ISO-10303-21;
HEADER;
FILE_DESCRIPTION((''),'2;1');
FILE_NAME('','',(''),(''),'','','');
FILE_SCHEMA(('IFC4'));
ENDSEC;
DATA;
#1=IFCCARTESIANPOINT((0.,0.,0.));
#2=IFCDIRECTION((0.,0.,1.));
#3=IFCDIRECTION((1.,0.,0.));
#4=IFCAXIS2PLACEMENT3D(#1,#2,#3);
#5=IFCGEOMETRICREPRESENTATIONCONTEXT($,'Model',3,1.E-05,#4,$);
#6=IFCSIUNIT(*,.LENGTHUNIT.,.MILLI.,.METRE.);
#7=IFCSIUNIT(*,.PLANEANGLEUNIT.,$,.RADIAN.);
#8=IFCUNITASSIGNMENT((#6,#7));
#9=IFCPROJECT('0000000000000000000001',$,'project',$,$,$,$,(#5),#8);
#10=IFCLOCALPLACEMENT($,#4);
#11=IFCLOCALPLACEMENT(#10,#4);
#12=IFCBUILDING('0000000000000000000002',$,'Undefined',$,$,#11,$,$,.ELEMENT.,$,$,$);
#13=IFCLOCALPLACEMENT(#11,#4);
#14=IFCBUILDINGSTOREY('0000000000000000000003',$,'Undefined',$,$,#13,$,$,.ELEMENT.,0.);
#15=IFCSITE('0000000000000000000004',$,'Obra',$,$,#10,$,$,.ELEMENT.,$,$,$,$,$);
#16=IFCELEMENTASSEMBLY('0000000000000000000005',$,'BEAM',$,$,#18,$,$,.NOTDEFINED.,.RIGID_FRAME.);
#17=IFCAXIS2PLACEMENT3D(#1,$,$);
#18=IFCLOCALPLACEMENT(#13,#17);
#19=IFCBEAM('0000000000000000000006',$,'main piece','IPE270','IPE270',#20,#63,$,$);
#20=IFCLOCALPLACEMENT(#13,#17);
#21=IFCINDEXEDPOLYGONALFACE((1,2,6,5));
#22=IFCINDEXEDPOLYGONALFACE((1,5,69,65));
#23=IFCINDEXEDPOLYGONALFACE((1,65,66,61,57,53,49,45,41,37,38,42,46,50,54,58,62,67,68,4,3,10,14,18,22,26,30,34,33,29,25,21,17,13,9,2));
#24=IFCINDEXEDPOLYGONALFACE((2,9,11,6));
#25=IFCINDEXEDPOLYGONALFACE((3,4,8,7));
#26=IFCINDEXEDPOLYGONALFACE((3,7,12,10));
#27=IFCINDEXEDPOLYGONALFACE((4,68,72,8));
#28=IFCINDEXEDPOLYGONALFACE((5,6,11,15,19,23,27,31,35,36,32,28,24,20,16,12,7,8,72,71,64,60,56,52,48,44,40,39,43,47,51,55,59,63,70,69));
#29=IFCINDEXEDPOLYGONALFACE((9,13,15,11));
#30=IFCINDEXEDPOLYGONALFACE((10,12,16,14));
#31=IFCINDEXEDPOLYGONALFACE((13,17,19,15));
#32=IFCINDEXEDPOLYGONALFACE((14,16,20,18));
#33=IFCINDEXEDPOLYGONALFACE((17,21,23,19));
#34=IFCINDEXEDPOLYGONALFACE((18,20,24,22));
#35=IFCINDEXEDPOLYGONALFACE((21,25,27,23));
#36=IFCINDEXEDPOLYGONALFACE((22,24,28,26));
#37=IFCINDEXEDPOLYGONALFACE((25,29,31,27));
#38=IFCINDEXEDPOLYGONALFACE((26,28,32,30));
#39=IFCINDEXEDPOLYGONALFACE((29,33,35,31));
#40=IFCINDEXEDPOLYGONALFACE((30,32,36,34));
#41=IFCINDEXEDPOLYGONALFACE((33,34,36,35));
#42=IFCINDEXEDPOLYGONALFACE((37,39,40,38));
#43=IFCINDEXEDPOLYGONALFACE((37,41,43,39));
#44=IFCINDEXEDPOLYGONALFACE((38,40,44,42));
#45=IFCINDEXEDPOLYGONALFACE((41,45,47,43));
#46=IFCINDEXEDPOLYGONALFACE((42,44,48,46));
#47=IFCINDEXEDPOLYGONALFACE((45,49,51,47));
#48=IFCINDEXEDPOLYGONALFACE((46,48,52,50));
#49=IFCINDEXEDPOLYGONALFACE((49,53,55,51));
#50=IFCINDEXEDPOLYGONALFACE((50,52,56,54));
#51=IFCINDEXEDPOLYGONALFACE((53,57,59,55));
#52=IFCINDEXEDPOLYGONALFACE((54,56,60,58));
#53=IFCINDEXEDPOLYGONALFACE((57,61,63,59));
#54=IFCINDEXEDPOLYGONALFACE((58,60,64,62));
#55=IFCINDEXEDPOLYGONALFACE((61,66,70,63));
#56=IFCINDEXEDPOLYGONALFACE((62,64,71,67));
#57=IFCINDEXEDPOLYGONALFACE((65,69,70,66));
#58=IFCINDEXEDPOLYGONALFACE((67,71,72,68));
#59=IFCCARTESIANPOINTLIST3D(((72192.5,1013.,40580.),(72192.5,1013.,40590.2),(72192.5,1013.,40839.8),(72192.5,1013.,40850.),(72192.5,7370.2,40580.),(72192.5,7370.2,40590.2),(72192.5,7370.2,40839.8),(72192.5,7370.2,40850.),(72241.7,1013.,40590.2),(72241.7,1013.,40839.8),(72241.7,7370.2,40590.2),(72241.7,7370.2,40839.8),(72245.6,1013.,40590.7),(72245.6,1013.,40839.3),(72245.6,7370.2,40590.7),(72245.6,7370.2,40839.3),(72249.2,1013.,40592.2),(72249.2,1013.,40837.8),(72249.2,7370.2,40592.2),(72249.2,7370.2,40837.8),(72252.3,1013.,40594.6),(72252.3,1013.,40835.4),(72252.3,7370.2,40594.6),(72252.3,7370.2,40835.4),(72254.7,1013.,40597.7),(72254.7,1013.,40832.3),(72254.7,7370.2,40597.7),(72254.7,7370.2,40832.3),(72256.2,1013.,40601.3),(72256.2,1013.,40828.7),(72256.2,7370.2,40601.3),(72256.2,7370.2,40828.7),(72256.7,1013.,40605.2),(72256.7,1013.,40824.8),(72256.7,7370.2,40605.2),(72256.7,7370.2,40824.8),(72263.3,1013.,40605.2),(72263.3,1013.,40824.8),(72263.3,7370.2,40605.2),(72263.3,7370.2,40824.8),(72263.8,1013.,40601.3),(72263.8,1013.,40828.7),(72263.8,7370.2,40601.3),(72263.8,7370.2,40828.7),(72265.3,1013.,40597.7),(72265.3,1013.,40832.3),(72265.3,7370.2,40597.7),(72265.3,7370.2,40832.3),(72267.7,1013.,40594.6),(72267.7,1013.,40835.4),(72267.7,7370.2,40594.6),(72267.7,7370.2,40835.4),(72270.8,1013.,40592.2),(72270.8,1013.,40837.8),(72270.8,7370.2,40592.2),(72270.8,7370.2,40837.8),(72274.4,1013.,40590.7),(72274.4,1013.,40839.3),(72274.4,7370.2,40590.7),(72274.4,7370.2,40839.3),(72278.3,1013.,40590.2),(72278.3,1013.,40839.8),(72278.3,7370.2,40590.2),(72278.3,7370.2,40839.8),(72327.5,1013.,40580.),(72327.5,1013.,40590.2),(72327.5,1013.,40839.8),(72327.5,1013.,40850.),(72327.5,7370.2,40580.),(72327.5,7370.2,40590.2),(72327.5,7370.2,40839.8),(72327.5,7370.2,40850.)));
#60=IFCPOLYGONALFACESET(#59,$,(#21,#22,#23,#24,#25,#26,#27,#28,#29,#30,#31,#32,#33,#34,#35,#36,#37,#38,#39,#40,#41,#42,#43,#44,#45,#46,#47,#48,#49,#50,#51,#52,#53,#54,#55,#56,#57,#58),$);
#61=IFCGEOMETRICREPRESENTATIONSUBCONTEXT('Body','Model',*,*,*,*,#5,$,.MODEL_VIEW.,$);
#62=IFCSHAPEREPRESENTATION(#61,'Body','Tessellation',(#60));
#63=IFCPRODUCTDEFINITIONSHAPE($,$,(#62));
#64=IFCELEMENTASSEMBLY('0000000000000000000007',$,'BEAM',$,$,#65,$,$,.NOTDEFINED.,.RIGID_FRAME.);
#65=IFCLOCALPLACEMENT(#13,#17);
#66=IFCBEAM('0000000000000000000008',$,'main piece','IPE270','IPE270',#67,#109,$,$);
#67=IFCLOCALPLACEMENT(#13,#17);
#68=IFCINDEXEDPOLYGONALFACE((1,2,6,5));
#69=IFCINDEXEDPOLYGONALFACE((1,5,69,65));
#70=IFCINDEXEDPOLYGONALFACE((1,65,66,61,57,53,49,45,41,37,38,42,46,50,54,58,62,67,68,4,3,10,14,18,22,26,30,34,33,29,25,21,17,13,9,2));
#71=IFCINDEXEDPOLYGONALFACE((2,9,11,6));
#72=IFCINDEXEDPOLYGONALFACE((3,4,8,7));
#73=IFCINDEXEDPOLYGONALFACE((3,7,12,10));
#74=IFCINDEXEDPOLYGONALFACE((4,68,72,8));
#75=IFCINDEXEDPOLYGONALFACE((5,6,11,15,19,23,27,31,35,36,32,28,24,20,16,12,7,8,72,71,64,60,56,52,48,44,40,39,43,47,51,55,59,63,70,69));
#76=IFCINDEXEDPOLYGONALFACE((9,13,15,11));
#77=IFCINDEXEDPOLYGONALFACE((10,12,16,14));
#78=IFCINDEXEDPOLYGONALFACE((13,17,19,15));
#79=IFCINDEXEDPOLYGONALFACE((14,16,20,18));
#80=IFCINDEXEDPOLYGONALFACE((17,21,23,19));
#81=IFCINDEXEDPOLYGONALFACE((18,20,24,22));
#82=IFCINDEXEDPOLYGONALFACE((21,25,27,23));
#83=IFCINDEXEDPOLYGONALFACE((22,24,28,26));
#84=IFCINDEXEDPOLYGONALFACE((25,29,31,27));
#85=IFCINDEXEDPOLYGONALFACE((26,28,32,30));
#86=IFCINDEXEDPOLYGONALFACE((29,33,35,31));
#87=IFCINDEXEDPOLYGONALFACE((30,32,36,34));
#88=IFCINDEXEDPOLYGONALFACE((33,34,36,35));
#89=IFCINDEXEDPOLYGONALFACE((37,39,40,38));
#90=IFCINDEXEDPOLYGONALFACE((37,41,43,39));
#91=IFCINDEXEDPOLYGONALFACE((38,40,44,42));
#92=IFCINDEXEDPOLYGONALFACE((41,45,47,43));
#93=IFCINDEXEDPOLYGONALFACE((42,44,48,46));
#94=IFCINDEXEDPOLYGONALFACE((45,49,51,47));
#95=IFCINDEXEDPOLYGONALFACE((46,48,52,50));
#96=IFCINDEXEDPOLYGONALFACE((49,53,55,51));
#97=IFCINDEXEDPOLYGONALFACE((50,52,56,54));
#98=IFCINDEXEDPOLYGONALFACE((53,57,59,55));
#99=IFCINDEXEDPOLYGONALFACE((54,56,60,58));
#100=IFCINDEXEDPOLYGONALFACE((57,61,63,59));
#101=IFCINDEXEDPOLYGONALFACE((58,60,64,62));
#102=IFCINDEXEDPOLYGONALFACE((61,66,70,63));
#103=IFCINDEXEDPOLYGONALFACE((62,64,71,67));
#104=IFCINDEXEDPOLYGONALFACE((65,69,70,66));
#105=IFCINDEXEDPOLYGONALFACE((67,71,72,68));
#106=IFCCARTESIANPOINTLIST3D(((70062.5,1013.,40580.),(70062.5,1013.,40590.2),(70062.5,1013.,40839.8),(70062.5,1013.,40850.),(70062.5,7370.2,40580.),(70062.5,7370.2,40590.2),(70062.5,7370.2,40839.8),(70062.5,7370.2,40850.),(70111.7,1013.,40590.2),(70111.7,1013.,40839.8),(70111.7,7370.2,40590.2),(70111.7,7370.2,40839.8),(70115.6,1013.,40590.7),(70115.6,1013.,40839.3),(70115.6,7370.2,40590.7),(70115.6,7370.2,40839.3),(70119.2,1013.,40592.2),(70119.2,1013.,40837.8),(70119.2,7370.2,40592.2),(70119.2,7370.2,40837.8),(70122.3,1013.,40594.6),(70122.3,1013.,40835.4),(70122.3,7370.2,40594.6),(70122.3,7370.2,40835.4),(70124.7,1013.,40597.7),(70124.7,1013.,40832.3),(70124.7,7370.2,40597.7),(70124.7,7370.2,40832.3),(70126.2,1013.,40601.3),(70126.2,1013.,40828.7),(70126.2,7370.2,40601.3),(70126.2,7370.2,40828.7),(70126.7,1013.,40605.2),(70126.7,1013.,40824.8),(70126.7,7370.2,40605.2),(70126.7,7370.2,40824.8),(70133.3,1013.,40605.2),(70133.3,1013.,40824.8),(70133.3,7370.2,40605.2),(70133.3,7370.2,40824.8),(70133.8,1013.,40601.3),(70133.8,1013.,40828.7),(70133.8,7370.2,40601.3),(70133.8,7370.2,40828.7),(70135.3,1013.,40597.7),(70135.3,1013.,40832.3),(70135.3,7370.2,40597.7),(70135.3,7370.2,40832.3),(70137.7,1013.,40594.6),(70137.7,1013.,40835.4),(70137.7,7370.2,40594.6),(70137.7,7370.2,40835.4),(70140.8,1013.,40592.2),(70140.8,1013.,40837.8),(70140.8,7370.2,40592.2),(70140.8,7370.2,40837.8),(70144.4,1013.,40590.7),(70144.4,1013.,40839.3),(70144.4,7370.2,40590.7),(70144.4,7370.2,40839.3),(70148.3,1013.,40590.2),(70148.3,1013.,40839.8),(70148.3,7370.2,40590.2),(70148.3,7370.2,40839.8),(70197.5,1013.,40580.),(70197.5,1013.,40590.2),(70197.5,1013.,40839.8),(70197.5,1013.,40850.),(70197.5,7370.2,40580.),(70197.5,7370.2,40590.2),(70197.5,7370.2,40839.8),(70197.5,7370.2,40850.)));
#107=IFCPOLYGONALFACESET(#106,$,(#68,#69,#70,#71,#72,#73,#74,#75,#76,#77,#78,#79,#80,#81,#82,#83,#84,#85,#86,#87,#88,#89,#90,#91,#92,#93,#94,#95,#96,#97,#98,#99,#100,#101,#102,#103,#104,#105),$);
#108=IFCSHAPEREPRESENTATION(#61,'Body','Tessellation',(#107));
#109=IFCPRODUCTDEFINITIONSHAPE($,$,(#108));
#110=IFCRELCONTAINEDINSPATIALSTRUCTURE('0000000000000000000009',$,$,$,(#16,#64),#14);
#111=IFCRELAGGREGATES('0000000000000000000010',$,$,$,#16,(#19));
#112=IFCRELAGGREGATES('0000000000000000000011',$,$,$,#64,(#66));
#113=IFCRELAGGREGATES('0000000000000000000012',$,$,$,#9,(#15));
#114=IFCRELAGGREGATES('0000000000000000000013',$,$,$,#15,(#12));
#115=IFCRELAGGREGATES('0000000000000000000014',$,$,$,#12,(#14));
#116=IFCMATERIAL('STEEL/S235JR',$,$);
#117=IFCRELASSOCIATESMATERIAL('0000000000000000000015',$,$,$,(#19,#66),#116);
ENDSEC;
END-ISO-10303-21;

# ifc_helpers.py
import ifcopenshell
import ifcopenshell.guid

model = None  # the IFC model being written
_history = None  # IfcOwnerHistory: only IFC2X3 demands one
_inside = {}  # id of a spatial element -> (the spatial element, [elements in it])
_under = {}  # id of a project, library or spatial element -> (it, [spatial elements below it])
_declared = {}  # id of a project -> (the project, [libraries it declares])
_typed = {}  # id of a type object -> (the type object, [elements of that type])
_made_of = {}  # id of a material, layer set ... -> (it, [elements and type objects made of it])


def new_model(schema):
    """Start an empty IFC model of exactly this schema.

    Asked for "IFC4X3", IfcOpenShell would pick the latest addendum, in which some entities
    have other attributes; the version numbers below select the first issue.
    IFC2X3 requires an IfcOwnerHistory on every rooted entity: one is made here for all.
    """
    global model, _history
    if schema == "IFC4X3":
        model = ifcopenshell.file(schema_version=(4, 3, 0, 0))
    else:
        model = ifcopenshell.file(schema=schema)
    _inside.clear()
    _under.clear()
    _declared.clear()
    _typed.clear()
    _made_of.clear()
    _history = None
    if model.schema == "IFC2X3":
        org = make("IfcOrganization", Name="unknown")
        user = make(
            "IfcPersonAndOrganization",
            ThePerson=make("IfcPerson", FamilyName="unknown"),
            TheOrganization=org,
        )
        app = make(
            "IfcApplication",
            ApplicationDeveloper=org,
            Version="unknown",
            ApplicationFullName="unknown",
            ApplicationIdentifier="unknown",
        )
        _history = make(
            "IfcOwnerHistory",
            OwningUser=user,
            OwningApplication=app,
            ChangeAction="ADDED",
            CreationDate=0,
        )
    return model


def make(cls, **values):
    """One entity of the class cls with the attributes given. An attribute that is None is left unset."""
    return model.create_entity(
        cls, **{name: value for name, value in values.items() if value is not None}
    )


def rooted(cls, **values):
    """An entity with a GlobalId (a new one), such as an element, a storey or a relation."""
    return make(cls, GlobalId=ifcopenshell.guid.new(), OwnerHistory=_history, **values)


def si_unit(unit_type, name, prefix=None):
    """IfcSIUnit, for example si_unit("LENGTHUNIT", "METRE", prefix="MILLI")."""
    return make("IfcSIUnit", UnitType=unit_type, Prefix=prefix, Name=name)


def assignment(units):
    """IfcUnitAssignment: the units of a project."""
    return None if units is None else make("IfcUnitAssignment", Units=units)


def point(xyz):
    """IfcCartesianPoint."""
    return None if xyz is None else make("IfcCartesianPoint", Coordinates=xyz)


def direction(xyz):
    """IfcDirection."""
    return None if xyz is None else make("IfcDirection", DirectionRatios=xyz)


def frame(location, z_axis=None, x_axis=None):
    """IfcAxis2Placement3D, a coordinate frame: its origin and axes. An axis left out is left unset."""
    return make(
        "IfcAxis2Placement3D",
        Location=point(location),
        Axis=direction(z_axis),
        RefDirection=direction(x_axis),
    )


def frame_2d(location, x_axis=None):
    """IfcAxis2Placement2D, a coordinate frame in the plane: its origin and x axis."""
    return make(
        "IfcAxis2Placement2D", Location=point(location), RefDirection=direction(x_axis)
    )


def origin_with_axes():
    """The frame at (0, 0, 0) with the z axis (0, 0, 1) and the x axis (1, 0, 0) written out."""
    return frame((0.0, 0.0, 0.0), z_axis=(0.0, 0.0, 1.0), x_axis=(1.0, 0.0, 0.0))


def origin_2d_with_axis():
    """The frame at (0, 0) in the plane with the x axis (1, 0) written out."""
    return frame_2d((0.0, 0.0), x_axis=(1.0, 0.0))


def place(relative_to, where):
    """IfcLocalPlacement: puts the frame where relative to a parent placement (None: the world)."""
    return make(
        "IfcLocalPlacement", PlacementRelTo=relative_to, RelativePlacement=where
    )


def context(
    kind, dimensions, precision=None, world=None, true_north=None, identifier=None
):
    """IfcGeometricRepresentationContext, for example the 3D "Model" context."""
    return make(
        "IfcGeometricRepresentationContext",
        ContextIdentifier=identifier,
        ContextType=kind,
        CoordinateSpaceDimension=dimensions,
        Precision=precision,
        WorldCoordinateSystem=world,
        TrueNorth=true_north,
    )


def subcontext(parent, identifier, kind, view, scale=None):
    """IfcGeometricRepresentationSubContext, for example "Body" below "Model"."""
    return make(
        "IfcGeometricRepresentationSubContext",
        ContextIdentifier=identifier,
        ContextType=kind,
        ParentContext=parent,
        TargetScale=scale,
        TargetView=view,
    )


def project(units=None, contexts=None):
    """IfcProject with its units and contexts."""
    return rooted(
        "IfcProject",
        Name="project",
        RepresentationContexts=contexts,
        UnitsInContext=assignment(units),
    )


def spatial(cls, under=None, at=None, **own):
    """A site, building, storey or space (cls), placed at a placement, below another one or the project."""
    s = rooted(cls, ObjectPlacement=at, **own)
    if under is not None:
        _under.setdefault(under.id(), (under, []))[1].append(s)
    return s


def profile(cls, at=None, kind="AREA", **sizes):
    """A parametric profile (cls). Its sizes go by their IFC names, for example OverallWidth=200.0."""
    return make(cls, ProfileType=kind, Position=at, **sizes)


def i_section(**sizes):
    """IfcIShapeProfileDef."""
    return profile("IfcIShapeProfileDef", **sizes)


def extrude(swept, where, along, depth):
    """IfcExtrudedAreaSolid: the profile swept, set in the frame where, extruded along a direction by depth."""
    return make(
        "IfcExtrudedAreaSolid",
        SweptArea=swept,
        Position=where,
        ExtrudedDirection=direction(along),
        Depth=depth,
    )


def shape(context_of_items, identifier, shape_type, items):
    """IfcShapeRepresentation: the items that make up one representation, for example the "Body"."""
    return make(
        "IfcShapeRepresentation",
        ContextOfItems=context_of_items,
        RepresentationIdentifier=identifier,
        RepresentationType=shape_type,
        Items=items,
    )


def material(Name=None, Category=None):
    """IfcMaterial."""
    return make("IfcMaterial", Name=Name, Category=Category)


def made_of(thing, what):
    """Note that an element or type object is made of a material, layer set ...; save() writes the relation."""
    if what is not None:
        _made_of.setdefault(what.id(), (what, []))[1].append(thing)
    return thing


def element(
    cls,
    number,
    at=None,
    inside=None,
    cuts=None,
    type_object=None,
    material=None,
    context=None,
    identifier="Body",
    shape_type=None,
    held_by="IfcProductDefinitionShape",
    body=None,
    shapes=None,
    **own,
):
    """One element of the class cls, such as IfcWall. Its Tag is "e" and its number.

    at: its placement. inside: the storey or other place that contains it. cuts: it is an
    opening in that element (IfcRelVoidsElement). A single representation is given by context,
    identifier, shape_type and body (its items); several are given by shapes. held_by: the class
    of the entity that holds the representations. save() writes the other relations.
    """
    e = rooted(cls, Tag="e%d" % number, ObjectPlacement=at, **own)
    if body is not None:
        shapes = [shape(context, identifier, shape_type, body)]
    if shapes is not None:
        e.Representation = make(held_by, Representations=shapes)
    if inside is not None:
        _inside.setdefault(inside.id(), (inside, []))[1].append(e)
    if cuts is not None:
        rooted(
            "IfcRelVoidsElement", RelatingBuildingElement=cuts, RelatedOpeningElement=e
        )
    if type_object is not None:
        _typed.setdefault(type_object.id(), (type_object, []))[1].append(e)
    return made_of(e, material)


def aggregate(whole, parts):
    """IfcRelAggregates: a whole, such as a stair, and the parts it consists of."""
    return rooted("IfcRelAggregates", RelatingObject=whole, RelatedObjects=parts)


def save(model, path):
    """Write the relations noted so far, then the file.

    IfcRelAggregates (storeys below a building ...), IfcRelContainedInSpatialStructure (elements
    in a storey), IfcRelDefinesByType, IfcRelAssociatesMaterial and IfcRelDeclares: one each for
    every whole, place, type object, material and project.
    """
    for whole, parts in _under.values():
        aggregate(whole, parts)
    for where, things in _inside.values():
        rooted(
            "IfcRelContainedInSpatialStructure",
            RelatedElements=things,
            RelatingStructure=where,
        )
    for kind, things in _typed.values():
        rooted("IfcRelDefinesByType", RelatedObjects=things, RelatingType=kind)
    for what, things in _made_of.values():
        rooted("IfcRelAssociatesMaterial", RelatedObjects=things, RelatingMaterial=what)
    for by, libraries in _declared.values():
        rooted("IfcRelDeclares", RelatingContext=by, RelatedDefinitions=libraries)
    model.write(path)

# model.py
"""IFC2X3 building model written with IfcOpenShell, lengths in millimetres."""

from ifc_helpers import new_model, si_unit, frame, origin_with_axes, origin_2d_with_axis, place, context, subcontext, project, spatial, i_section, extrude, material, element, aggregate, save


model = new_model("IFC2X3")

# Units and contexts
model_context = context("Model", 3, precision=1e-05, world=origin_with_axes())
body_context = subcontext(model_context, "Body", "Model", "MODEL_VIEW")
ifc_project = project(units=[si_unit("LENGTHUNIT", "METRE", prefix="MILLI"), si_unit("PLANEANGLEUNIT", "RADIAN")], contexts=[model_context])

# Site, building, storey
site_placement = place(None, origin_with_axes())
site = spatial("IfcSite", under=ifc_project, at=site_placement, Name="Obra", CompositionType="ELEMENT")
building_placement = place(site_placement, origin_with_axes())
building = spatial("IfcBuilding", under=site, at=building_placement, Name="Undefined", CompositionType="ELEMENT")
storey_placement = place(building_placement, origin_with_axes())
storey = spatial("IfcBuildingStorey", under=building, at=storey_placement, Name="Undefined", CompositionType="ELEMENT", Elevation=0.0)

# Element assemblies, beams
ifc_material_1 = material(Name="STEEL/S235JR")
assembly_1_placement = place(storey_placement, origin_with_axes())
assembly_1 = element("IfcElementAssembly", 1, at=assembly_1_placement, inside=storey, Name="BEAM", AssemblyPlace="NOTDEFINED", PredefinedType="RIGID_FRAME")
beam_1_placement = place(assembly_1_placement, frame((72260.0, 7370.2, 40715.0), z_axis=(0.0, 0.0, 1.0), x_axis=(0.0, -1.0, 0.0)))
beam_1 = element("IfcBeam", 2, at=beam_1_placement, material=ifc_material_1, Name="main piece", Description="IPE270", ObjectType="IPE270", context=body_context, shape_type="SweptSolid", body=[
    extrude(i_section(OverallWidth=135.0, OverallDepth=270.0, WebThickness=6.6, FlangeThickness=10.2, FilletRadius=15.0, at=origin_2d_with_axis()), frame((6357.2, 0.0, 0.0), z_axis=(-1.0, 0.0, 0.0), x_axis=(0.0, -1.0, 0.0)), (0.0, 0.0, 1.0), 6357.2),
])
aggregate(assembly_1, [beam_1])
assembly_2_placement = place(storey_placement, origin_with_axes())
assembly_2 = element("IfcElementAssembly", 3, at=assembly_2_placement, inside=storey, Name="BEAM", AssemblyPlace="NOTDEFINED", PredefinedType="RIGID_FRAME")
beam_2_placement = place(assembly_2_placement, frame((70130.0, 1013.0, 40715.0), z_axis=(0.0, 0.0, 1.0), x_axis=(0.0, 1.0, 0.0)))
beam_2 = element("IfcBeam", 4, at=beam_2_placement, material=ifc_material_1, Name="main piece", Description="IPE270", ObjectType="IPE270", context=body_context, shape_type="SweptSolid", body=[
    extrude(i_section(OverallWidth=135.0, OverallDepth=270.0, WebThickness=6.6, FlangeThickness=10.2, FilletRadius=15.0, at=origin_2d_with_axis()), frame((6357.2, 0.0, 0.0), z_axis=(-1.0, 0.0, 0.0), x_axis=(0.0, -1.0, 0.0)), (0.0, 0.0, 1.0), 6357.2),
])
aggregate(assembly_2, [beam_2])

save(model, "model.ifc")
